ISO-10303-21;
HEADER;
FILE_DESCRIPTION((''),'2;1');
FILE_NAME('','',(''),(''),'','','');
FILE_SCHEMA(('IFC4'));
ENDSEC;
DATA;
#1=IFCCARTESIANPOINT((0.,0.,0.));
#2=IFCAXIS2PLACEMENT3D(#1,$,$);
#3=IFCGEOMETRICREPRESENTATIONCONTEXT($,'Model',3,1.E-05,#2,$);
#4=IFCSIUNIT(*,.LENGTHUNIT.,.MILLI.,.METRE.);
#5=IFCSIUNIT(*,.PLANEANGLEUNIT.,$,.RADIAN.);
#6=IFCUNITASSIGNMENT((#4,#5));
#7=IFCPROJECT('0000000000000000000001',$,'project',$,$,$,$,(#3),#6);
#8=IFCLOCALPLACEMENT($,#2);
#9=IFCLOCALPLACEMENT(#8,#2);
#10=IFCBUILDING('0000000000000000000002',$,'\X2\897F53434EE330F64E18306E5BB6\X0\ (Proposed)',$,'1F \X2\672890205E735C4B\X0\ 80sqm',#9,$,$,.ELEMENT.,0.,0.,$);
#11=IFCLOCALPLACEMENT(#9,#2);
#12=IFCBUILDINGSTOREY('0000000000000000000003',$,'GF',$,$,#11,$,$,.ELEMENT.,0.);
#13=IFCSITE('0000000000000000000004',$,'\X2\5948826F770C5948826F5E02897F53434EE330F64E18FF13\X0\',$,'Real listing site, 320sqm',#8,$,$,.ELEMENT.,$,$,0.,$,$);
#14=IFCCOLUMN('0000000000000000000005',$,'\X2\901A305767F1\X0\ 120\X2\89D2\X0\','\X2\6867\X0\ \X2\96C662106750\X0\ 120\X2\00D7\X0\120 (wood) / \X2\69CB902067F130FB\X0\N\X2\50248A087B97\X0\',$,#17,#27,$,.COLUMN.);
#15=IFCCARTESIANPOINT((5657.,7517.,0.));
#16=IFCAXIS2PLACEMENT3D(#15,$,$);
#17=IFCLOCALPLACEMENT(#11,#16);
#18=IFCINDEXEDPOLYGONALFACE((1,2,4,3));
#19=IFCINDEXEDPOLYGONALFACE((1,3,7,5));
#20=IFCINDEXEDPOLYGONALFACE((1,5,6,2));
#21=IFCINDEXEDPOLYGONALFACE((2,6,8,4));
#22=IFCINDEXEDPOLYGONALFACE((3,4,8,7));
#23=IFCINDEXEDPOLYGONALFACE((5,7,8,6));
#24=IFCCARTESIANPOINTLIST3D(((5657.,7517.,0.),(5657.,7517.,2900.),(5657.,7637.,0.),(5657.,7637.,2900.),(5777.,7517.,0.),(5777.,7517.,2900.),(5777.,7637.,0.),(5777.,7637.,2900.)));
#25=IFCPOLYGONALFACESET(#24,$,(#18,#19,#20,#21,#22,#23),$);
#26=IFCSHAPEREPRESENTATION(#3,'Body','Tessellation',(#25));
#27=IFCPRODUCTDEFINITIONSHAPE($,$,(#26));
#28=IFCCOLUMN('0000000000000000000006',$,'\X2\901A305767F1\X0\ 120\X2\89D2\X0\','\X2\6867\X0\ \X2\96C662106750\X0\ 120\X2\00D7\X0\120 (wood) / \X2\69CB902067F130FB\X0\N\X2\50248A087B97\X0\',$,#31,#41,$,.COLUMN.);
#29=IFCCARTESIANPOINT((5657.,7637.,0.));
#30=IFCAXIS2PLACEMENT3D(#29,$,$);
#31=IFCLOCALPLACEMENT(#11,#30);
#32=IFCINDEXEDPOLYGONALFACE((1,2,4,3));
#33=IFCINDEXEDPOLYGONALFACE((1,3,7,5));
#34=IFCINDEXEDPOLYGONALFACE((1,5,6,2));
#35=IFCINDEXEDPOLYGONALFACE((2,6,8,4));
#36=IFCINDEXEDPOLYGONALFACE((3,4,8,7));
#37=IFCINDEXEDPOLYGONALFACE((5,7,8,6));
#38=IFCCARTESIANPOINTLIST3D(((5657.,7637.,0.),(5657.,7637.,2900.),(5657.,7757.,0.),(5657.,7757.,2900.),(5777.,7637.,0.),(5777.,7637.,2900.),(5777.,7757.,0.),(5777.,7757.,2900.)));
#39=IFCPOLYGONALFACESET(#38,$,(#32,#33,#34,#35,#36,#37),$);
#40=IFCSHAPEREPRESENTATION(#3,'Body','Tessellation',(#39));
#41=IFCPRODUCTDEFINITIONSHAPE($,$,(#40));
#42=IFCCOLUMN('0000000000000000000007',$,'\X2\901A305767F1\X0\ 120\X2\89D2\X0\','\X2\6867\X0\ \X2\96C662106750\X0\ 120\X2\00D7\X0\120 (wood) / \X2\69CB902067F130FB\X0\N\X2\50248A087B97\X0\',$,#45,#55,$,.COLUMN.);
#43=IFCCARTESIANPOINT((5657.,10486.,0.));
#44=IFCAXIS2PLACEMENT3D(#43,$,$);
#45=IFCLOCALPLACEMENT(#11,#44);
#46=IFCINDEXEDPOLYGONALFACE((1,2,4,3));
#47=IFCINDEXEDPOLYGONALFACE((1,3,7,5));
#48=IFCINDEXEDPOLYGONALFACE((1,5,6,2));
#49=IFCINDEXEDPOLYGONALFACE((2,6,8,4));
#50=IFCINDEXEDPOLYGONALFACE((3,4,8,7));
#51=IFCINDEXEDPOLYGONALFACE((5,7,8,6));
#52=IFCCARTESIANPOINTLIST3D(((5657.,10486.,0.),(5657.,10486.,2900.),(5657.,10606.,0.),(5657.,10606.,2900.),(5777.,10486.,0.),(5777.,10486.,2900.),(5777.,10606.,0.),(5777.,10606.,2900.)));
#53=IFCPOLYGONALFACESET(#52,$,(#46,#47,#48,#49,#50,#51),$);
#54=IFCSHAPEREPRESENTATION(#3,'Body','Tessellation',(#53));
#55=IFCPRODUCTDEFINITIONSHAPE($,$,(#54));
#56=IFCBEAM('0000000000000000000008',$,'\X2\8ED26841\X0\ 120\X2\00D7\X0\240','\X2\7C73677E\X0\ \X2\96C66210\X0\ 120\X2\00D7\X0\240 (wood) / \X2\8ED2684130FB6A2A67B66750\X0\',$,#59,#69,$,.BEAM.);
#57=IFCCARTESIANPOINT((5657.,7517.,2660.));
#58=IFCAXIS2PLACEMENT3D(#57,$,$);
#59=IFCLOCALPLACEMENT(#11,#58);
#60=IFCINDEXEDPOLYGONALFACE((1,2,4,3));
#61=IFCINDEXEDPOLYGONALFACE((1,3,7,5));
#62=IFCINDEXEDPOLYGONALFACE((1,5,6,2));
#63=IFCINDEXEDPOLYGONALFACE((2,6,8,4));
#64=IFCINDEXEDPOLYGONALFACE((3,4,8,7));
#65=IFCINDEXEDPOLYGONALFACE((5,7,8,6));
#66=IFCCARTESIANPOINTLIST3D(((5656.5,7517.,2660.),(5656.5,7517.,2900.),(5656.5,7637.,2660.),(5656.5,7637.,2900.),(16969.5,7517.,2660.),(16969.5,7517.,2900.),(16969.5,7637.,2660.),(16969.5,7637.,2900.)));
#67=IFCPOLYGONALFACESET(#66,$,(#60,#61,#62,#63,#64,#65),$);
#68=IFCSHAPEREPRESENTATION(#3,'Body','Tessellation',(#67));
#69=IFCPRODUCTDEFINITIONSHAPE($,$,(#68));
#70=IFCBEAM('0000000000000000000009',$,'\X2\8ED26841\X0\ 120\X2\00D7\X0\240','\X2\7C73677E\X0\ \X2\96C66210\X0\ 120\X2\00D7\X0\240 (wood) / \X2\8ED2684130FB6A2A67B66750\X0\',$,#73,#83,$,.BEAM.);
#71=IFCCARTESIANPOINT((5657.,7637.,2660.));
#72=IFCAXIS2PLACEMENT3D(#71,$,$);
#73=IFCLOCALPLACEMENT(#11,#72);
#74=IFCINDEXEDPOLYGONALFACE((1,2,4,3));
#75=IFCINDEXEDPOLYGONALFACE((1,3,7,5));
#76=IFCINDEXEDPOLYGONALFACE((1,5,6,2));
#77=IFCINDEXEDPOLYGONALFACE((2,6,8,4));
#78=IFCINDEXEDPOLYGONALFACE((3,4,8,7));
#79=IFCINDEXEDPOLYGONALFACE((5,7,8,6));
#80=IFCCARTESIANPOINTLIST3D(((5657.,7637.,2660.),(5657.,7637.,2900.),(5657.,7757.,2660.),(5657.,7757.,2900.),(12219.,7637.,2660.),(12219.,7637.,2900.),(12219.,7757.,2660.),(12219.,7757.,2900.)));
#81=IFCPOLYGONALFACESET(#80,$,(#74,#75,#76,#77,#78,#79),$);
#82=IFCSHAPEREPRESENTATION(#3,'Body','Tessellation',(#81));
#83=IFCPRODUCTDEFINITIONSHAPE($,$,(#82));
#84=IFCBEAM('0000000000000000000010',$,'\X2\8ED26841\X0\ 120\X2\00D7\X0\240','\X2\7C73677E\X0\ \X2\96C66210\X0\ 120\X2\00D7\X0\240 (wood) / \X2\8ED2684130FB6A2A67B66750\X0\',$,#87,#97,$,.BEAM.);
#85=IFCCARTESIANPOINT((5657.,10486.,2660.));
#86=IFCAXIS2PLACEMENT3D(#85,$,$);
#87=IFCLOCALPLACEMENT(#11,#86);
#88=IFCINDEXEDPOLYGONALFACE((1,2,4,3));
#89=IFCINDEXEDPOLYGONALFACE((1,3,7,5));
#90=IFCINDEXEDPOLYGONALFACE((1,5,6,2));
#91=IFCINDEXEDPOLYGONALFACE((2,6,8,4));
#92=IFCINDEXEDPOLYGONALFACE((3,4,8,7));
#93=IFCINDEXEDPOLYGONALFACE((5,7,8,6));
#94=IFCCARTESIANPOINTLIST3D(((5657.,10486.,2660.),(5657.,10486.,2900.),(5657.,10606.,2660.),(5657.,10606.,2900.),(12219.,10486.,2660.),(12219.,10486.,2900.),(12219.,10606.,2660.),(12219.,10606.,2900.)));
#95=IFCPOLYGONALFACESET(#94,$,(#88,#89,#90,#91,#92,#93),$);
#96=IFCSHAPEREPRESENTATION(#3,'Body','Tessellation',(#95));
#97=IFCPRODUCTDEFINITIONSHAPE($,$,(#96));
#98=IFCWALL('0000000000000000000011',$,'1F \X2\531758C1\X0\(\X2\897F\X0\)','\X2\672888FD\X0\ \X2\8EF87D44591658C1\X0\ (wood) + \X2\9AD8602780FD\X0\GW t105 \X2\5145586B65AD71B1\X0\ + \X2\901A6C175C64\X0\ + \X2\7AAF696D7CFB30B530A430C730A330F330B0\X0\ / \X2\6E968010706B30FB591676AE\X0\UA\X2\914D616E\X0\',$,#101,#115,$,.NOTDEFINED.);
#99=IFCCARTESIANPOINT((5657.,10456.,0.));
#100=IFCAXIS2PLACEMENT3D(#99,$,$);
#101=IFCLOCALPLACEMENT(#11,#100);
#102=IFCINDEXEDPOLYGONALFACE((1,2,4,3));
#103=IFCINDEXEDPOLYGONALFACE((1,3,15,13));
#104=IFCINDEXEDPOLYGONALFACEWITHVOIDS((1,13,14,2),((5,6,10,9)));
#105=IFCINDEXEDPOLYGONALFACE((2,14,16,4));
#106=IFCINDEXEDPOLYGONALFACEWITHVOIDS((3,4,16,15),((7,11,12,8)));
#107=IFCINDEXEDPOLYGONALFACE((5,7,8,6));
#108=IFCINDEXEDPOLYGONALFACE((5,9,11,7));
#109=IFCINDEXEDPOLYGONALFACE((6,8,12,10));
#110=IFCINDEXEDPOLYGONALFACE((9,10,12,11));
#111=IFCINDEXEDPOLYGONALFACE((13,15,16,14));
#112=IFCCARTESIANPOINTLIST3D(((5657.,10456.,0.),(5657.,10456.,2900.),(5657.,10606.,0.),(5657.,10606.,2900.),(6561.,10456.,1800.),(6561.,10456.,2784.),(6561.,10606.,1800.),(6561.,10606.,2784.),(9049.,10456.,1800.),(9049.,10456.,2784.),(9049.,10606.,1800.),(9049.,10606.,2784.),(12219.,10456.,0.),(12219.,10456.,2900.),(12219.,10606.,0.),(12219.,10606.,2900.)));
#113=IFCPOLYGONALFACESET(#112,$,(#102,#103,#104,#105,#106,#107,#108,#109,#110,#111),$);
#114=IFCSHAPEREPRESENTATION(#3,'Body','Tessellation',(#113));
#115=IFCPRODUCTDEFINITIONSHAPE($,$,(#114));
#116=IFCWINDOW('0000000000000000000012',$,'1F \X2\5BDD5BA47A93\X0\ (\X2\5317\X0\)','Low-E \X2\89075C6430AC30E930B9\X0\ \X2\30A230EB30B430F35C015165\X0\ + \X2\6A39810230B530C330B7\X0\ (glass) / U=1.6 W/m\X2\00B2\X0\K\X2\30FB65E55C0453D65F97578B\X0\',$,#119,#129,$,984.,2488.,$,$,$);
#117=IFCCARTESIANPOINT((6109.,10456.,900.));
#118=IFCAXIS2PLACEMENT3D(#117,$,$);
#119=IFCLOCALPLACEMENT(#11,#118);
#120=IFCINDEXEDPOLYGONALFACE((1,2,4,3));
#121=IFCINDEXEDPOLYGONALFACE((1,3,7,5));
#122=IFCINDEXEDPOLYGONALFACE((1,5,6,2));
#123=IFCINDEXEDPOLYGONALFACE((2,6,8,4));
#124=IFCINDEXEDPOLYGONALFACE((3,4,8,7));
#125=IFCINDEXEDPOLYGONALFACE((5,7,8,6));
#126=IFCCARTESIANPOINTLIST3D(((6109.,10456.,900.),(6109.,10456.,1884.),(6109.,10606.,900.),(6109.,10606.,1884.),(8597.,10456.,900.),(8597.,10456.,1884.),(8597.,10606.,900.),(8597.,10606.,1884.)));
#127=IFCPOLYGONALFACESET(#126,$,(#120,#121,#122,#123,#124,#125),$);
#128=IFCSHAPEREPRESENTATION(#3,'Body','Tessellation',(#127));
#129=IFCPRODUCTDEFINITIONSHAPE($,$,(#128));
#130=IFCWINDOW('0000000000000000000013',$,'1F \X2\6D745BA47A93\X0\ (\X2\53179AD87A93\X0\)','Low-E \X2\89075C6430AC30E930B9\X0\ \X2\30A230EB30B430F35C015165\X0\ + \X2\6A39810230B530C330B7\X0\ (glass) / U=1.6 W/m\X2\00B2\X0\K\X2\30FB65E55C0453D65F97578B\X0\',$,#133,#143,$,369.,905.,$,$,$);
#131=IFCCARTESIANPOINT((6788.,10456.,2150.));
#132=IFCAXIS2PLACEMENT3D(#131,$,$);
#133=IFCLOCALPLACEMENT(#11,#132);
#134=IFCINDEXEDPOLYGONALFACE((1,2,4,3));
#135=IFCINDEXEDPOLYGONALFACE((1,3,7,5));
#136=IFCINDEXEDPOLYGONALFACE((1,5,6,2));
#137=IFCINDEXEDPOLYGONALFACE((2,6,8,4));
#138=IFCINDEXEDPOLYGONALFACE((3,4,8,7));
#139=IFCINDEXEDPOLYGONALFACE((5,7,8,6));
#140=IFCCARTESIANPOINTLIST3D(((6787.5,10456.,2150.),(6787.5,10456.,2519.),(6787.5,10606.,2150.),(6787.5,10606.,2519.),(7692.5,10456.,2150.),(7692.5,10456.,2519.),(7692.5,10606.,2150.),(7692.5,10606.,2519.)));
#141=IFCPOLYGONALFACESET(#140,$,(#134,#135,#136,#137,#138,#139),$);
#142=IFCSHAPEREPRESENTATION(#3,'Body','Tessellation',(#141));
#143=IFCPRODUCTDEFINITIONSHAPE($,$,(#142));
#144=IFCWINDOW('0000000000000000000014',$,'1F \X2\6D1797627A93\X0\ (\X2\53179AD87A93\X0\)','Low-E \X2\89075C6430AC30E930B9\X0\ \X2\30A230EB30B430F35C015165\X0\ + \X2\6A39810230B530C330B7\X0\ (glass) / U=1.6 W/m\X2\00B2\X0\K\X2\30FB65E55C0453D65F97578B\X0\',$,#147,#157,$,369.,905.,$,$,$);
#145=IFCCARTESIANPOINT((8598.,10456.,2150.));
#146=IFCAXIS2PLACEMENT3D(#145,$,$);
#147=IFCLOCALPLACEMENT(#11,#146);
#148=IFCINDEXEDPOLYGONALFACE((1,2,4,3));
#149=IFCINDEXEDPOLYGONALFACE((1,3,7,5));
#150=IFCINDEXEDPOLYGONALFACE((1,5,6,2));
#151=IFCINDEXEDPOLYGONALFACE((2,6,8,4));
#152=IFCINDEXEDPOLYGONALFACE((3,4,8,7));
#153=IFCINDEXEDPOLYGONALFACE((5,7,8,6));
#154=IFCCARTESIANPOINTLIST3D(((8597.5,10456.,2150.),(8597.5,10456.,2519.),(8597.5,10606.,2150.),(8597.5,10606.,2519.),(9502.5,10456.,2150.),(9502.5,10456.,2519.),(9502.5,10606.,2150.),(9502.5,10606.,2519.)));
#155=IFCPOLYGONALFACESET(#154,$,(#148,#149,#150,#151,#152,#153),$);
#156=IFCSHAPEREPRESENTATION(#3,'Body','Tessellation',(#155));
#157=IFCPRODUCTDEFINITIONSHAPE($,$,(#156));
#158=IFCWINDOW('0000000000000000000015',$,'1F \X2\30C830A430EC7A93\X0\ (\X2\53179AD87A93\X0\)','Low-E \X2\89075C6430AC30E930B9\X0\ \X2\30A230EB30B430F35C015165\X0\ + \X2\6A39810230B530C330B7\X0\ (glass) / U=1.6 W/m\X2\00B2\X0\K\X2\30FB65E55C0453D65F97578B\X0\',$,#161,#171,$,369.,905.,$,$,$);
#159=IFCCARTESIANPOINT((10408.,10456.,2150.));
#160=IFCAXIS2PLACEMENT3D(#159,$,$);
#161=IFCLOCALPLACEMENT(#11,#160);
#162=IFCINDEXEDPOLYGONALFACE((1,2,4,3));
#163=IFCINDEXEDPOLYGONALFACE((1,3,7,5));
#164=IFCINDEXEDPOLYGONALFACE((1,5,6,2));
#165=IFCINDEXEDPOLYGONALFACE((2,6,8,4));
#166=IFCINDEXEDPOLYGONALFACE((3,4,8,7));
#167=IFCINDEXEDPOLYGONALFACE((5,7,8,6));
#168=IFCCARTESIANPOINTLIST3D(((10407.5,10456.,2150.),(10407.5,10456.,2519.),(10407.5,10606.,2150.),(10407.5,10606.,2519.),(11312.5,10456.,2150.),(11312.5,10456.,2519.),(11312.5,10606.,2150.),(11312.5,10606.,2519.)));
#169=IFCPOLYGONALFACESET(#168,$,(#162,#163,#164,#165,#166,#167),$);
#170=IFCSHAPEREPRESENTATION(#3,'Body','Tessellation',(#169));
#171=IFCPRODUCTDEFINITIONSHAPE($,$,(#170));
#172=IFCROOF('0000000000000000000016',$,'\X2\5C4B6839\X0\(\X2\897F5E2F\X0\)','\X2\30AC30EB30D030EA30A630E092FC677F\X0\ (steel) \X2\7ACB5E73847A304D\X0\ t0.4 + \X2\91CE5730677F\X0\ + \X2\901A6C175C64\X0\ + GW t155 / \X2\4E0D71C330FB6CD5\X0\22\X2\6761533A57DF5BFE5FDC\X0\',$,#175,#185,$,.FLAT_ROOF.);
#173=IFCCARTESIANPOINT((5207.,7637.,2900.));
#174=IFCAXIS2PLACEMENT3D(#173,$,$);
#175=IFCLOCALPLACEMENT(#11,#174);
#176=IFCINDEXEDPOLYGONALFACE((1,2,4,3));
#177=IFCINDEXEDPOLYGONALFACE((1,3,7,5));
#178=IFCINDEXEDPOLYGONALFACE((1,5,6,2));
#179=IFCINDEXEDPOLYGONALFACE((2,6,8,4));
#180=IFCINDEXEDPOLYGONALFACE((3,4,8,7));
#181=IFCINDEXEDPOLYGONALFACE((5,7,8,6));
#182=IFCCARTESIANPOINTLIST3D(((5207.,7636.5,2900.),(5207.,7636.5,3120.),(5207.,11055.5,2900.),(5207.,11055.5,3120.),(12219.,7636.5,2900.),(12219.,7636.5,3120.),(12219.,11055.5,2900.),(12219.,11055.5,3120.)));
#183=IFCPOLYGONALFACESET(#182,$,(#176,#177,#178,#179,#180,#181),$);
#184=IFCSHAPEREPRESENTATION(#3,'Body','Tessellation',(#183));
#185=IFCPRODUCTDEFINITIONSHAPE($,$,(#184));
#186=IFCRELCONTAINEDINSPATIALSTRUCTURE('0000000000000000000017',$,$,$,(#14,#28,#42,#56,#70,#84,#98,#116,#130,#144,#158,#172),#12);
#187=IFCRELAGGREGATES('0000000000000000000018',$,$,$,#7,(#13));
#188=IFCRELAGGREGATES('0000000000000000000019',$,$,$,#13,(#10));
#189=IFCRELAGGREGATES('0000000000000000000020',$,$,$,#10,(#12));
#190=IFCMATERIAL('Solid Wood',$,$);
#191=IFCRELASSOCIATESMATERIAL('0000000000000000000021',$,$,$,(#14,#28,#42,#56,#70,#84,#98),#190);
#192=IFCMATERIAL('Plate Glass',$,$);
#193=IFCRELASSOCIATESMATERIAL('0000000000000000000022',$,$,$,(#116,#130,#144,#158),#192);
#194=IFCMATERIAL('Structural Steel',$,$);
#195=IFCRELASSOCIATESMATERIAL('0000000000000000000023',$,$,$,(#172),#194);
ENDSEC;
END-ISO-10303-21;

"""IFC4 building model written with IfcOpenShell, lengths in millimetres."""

from ifc_helpers import new_model, si_unit, frame, frame_2d, origin, place, context, project, spatial, rectangle, extrude, material, element, fill, save


model = new_model("IFC4")

# Units and contexts
model_context = context("Model", 3, precision=1e-05, world=origin())
ifc_project = project(units=[si_unit("LENGTHUNIT", "METRE", prefix="MILLI"), si_unit("PLANEANGLEUNIT", "RADIAN")], contexts=[model_context])

# Site, building, storey
site_placement = place(None, origin())
site = spatial("IfcSite", under=ifc_project, at=site_placement, Name="奈良県奈良市西千代ヶ丘３", ObjectType="Real listing site, 320sqm", CompositionType="ELEMENT", RefElevation=0.0)
building_placement = place(site_placement, origin())
building = spatial("IfcBuilding", under=site, at=building_placement, Name="西千代ヶ丘の家 (Proposed)", ObjectType="1F 木造平屋 80sqm", CompositionType="ELEMENT", ElevationOfRefHeight=0.0, ElevationOfTerrain=0.0)
storey_placement = place(building_placement, origin())
storey = spatial("IfcBuildingStorey", under=building, at=storey_placement, Name="GF", CompositionType="ELEMENT", Elevation=0.0)

# Columns
ifc_material_1 = material(Name="Solid Wood")
column_1_placement = place(storey_placement, frame((5657.0, 7517.0, 0.0)))
element("IfcColumn", 1, at=column_1_placement, inside=storey, material=ifc_material_1, Name="通し柱 120角", Description="桧 集成材 120×120 (wood) / 構造柱・N値計算", PredefinedType="COLUMN", context=model_context, shape_type="SweptSolid", body=[
    extrude(rectangle(XDim=120.0, YDim=120.0, at=frame_2d((60.0, 60.0))), frame((5657.0, 7517.0, 0.0)), (0.0, 0.0, 1.0), 2900.0),
])
column_2_placement = place(storey_placement, frame((5657.0, 7637.0, 0.0)))
element("IfcColumn", 2, at=column_2_placement, inside=storey, material=ifc_material_1, Name="通し柱 120角", Description="桧 集成材 120×120 (wood) / 構造柱・N値計算", PredefinedType="COLUMN", context=model_context, shape_type="SweptSolid", body=[
    extrude(rectangle(XDim=120.0, YDim=120.0, at=frame_2d((60.0, 60.0))), frame((5657.0, 7637.0, 0.0)), (0.0, 0.0, 1.0), 2900.0),
])
column_3_placement = place(storey_placement, frame((5657.0, 10486.0, 0.0)))
element("IfcColumn", 3, at=column_3_placement, inside=storey, material=ifc_material_1, Name="通し柱 120角", Description="桧 集成材 120×120 (wood) / 構造柱・N値計算", PredefinedType="COLUMN", context=model_context, shape_type="SweptSolid", body=[
    extrude(rectangle(XDim=120.0, YDim=120.0, at=frame_2d((60.0, 60.0))), frame((5657.0, 10486.0, 0.0)), (0.0, 0.0, 1.0), 2900.0),
])

# Beams
beam_1_placement = place(storey_placement, frame((5657.0, 7517.0, 2660.0)))
element("IfcBeam", 4, at=beam_1_placement, inside=storey, material=ifc_material_1, Name="軒桁 120×240", Description="米松 集成 120×240 (wood) / 軒桁・横架材", PredefinedType="BEAM", context=model_context, shape_type="SweptSolid", body=[
    extrude(rectangle(XDim=11313.0, YDim=120.0, at=frame_2d((5656.0, 60.0))), frame((5657.0, 7517.0, 2660.0)), (0.0, 0.0, 1.0), 240.0),
])
beam_2_placement = place(storey_placement, frame((5657.0, 7637.0, 2660.0)))
element("IfcBeam", 5, at=beam_2_placement, inside=storey, material=ifc_material_1, Name="軒桁 120×240", Description="米松 集成 120×240 (wood) / 軒桁・横架材", PredefinedType="BEAM", context=model_context, shape_type="SweptSolid", body=[
    extrude(rectangle(XDim=6562.0, YDim=120.0, at=frame_2d((3281.0, 60.0))), frame((5657.0, 7637.0, 2660.0)), (0.0, 0.0, 1.0), 240.0),
])
beam_3_placement = place(storey_placement, frame((5657.0, 10486.0, 2660.0)))
element("IfcBeam", 6, at=beam_3_placement, inside=storey, material=ifc_material_1, Name="軒桁 120×240", Description="米松 集成 120×240 (wood) / 軒桁・横架材", PredefinedType="BEAM", context=model_context, shape_type="SweptSolid", body=[
    extrude(rectangle(XDim=6562.0, YDim=120.0, at=frame_2d((3281.0, 60.0))), frame((5657.0, 10486.0, 2660.0)), (0.0, 0.0, 1.0), 240.0),
])

# Wall, openings, windows
wall_1_placement = place(storey_placement, frame((5657.0, 10456.0, 0.0)))
wall_1 = element("IfcWall", 7, at=wall_1_placement, inside=storey, material=ifc_material_1, Name="1F 北壁(西)", Description="木製 軸組外壁 (wood) + 高性能GW t105 充填断熱 + 通気層 + 窯業系サイディング / 準耐火・外皮UA配慮", PredefinedType="NOTDEFINED", context=model_context, shape_type="SweptSolid", body=[
    extrude(rectangle(XDim=6562.0, YDim=150.0, at=frame_2d((3281.0, 75.0))), frame((5657.0, 10456.0, 0.0)), (0.0, 0.0, 1.0), 2900.0),
])
opening_1_placement = place(storey_placement, frame((6109.0, 10456.0, 900.0)))
opening_1 = element("IfcOpeningElement", 8, at=opening_1_placement, cuts=wall_1, PredefinedType="NOTDEFINED", context=model_context, shape_type="SweptSolid", body=[
    extrude(rectangle(XDim=2488.0, YDim=150.0, at=frame_2d((1244.0, 75.0))), frame((6109.0, 10456.0, 900.0)), (0.0, 0.0, 1.0), 984.0),
])
opening_2_placement = place(storey_placement, frame((6788.0, 10456.0, 2150.0)))
opening_2 = element("IfcOpeningElement", 9, at=opening_2_placement, cuts=wall_1, PredefinedType="NOTDEFINED", context=model_context, shape_type="SweptSolid", body=[
    extrude(rectangle(XDim=905.0, YDim=150.0, at=frame_2d((452.0, 75.0))), frame((6788.0, 10456.0, 2150.0)), (0.0, 0.0, 1.0), 369.0),
])
opening_3_placement = place(storey_placement, frame((8598.0, 10456.0, 2150.0)))
opening_3 = element("IfcOpeningElement", 10, at=opening_3_placement, cuts=wall_1, PredefinedType="NOTDEFINED", context=model_context, shape_type="SweptSolid", body=[
    extrude(rectangle(XDim=905.0, YDim=150.0, at=frame_2d((452.0, 75.0))), frame((8598.0, 10456.0, 2150.0)), (0.0, 0.0, 1.0), 369.0),
])
opening_4_placement = place(storey_placement, frame((10408.0, 10456.0, 2150.0)))
opening_4 = element("IfcOpeningElement", 11, at=opening_4_placement, cuts=wall_1, PredefinedType="NOTDEFINED", context=model_context, shape_type="SweptSolid", body=[
    extrude(rectangle(XDim=905.0, YDim=150.0, at=frame_2d((452.0, 75.0))), frame((10408.0, 10456.0, 2150.0)), (0.0, 0.0, 1.0), 369.0),
])
ifc_material_2 = material(Name="Plate Glass")
window_1_placement = place(storey_placement, frame((6109.0, 10456.0, 900.0)))
window_1 = element("IfcWindow", 12, at=window_1_placement, inside=storey, material=ifc_material_2, Name="1F 寝室窓 (北)", Description="Low-E 複層ガラス アルゴン封入 + 樹脂サッシ (glass) / U=1.6 W/m²K・日射取得型", OverallHeight=984.0, OverallWidth=2488.0, context=model_context, shape_type="SweptSolid", body=[
    extrude(rectangle(XDim=2488.0, YDim=150.0, at=frame_2d((1244.0, 75.0))), frame((6109.0, 10456.0, 900.0)), (0.0, 0.0, 1.0), 984.0),
])
fill(opening_1, window_1)
window_2_placement = place(storey_placement, frame((6788.0, 10456.0, 2150.0)))
window_2 = element("IfcWindow", 13, at=window_2_placement, inside=storey, material=ifc_material_2, Name="1F 浴室窓 (北高窓)", Description="Low-E 複層ガラス アルゴン封入 + 樹脂サッシ (glass) / U=1.6 W/m²K・日射取得型", OverallHeight=369.0, OverallWidth=905.0, context=model_context, shape_type="SweptSolid", body=[
    extrude(rectangle(XDim=905.0, YDim=150.0, at=frame_2d((452.0, 75.0))), frame((6788.0, 10456.0, 2150.0)), (0.0, 0.0, 1.0), 369.0),
])
fill(opening_2, window_2)
window_3_placement = place(storey_placement, frame((8598.0, 10456.0, 2150.0)))
window_3 = element("IfcWindow", 14, at=window_3_placement, inside=storey, material=ifc_material_2, Name="1F 洗面窓 (北高窓)", Description="Low-E 複層ガラス アルゴン封入 + 樹脂サッシ (glass) / U=1.6 W/m²K・日射取得型", OverallHeight=369.0, OverallWidth=905.0, context=model_context, shape_type="SweptSolid", body=[
    extrude(rectangle(XDim=905.0, YDim=150.0, at=frame_2d((452.0, 75.0))), frame((8598.0, 10456.0, 2150.0)), (0.0, 0.0, 1.0), 369.0),
])
fill(opening_3, window_3)
window_4_placement = place(storey_placement, frame((10408.0, 10456.0, 2150.0)))
window_4 = element("IfcWindow", 15, at=window_4_placement, inside=storey, material=ifc_material_2, Name="1F トイレ窓 (北高窓)", Description="Low-E 複層ガラス アルゴン封入 + 樹脂サッシ (glass) / U=1.6 W/m²K・日射取得型", OverallHeight=369.0, OverallWidth=905.0, context=model_context, shape_type="SweptSolid", body=[
    extrude(rectangle(XDim=905.0, YDim=150.0, at=frame_2d((452.0, 75.0))), frame((10408.0, 10456.0, 2150.0)), (0.0, 0.0, 1.0), 369.0),
])
fill(opening_4, window_4)

# Roof
ifc_material_3 = material(Name="Structural Steel")
roof_placement = place(storey_placement, frame((5207.0, 7637.0, 2900.0)))
element("IfcRoof", 16, at=roof_placement, inside=storey, material=ifc_material_3, Name="屋根(西帯)", Description="ガルバリウム鋼板 (steel) 立平葺き t0.4 + 野地板 + 通気層 + GW t155 / 不燃・法22条区域対応", PredefinedType="FLAT_ROOF", context=model_context, shape_type="SweptSolid", body=[
    extrude(rectangle(XDim=7012.0, YDim=3419.0, at=frame_2d((3506.0, 1709.0))), frame((5207.0, 7637.0, 2900.0)), (0.0, 0.0, 1.0), 220.0),
])

save(model, "model.ifc")
